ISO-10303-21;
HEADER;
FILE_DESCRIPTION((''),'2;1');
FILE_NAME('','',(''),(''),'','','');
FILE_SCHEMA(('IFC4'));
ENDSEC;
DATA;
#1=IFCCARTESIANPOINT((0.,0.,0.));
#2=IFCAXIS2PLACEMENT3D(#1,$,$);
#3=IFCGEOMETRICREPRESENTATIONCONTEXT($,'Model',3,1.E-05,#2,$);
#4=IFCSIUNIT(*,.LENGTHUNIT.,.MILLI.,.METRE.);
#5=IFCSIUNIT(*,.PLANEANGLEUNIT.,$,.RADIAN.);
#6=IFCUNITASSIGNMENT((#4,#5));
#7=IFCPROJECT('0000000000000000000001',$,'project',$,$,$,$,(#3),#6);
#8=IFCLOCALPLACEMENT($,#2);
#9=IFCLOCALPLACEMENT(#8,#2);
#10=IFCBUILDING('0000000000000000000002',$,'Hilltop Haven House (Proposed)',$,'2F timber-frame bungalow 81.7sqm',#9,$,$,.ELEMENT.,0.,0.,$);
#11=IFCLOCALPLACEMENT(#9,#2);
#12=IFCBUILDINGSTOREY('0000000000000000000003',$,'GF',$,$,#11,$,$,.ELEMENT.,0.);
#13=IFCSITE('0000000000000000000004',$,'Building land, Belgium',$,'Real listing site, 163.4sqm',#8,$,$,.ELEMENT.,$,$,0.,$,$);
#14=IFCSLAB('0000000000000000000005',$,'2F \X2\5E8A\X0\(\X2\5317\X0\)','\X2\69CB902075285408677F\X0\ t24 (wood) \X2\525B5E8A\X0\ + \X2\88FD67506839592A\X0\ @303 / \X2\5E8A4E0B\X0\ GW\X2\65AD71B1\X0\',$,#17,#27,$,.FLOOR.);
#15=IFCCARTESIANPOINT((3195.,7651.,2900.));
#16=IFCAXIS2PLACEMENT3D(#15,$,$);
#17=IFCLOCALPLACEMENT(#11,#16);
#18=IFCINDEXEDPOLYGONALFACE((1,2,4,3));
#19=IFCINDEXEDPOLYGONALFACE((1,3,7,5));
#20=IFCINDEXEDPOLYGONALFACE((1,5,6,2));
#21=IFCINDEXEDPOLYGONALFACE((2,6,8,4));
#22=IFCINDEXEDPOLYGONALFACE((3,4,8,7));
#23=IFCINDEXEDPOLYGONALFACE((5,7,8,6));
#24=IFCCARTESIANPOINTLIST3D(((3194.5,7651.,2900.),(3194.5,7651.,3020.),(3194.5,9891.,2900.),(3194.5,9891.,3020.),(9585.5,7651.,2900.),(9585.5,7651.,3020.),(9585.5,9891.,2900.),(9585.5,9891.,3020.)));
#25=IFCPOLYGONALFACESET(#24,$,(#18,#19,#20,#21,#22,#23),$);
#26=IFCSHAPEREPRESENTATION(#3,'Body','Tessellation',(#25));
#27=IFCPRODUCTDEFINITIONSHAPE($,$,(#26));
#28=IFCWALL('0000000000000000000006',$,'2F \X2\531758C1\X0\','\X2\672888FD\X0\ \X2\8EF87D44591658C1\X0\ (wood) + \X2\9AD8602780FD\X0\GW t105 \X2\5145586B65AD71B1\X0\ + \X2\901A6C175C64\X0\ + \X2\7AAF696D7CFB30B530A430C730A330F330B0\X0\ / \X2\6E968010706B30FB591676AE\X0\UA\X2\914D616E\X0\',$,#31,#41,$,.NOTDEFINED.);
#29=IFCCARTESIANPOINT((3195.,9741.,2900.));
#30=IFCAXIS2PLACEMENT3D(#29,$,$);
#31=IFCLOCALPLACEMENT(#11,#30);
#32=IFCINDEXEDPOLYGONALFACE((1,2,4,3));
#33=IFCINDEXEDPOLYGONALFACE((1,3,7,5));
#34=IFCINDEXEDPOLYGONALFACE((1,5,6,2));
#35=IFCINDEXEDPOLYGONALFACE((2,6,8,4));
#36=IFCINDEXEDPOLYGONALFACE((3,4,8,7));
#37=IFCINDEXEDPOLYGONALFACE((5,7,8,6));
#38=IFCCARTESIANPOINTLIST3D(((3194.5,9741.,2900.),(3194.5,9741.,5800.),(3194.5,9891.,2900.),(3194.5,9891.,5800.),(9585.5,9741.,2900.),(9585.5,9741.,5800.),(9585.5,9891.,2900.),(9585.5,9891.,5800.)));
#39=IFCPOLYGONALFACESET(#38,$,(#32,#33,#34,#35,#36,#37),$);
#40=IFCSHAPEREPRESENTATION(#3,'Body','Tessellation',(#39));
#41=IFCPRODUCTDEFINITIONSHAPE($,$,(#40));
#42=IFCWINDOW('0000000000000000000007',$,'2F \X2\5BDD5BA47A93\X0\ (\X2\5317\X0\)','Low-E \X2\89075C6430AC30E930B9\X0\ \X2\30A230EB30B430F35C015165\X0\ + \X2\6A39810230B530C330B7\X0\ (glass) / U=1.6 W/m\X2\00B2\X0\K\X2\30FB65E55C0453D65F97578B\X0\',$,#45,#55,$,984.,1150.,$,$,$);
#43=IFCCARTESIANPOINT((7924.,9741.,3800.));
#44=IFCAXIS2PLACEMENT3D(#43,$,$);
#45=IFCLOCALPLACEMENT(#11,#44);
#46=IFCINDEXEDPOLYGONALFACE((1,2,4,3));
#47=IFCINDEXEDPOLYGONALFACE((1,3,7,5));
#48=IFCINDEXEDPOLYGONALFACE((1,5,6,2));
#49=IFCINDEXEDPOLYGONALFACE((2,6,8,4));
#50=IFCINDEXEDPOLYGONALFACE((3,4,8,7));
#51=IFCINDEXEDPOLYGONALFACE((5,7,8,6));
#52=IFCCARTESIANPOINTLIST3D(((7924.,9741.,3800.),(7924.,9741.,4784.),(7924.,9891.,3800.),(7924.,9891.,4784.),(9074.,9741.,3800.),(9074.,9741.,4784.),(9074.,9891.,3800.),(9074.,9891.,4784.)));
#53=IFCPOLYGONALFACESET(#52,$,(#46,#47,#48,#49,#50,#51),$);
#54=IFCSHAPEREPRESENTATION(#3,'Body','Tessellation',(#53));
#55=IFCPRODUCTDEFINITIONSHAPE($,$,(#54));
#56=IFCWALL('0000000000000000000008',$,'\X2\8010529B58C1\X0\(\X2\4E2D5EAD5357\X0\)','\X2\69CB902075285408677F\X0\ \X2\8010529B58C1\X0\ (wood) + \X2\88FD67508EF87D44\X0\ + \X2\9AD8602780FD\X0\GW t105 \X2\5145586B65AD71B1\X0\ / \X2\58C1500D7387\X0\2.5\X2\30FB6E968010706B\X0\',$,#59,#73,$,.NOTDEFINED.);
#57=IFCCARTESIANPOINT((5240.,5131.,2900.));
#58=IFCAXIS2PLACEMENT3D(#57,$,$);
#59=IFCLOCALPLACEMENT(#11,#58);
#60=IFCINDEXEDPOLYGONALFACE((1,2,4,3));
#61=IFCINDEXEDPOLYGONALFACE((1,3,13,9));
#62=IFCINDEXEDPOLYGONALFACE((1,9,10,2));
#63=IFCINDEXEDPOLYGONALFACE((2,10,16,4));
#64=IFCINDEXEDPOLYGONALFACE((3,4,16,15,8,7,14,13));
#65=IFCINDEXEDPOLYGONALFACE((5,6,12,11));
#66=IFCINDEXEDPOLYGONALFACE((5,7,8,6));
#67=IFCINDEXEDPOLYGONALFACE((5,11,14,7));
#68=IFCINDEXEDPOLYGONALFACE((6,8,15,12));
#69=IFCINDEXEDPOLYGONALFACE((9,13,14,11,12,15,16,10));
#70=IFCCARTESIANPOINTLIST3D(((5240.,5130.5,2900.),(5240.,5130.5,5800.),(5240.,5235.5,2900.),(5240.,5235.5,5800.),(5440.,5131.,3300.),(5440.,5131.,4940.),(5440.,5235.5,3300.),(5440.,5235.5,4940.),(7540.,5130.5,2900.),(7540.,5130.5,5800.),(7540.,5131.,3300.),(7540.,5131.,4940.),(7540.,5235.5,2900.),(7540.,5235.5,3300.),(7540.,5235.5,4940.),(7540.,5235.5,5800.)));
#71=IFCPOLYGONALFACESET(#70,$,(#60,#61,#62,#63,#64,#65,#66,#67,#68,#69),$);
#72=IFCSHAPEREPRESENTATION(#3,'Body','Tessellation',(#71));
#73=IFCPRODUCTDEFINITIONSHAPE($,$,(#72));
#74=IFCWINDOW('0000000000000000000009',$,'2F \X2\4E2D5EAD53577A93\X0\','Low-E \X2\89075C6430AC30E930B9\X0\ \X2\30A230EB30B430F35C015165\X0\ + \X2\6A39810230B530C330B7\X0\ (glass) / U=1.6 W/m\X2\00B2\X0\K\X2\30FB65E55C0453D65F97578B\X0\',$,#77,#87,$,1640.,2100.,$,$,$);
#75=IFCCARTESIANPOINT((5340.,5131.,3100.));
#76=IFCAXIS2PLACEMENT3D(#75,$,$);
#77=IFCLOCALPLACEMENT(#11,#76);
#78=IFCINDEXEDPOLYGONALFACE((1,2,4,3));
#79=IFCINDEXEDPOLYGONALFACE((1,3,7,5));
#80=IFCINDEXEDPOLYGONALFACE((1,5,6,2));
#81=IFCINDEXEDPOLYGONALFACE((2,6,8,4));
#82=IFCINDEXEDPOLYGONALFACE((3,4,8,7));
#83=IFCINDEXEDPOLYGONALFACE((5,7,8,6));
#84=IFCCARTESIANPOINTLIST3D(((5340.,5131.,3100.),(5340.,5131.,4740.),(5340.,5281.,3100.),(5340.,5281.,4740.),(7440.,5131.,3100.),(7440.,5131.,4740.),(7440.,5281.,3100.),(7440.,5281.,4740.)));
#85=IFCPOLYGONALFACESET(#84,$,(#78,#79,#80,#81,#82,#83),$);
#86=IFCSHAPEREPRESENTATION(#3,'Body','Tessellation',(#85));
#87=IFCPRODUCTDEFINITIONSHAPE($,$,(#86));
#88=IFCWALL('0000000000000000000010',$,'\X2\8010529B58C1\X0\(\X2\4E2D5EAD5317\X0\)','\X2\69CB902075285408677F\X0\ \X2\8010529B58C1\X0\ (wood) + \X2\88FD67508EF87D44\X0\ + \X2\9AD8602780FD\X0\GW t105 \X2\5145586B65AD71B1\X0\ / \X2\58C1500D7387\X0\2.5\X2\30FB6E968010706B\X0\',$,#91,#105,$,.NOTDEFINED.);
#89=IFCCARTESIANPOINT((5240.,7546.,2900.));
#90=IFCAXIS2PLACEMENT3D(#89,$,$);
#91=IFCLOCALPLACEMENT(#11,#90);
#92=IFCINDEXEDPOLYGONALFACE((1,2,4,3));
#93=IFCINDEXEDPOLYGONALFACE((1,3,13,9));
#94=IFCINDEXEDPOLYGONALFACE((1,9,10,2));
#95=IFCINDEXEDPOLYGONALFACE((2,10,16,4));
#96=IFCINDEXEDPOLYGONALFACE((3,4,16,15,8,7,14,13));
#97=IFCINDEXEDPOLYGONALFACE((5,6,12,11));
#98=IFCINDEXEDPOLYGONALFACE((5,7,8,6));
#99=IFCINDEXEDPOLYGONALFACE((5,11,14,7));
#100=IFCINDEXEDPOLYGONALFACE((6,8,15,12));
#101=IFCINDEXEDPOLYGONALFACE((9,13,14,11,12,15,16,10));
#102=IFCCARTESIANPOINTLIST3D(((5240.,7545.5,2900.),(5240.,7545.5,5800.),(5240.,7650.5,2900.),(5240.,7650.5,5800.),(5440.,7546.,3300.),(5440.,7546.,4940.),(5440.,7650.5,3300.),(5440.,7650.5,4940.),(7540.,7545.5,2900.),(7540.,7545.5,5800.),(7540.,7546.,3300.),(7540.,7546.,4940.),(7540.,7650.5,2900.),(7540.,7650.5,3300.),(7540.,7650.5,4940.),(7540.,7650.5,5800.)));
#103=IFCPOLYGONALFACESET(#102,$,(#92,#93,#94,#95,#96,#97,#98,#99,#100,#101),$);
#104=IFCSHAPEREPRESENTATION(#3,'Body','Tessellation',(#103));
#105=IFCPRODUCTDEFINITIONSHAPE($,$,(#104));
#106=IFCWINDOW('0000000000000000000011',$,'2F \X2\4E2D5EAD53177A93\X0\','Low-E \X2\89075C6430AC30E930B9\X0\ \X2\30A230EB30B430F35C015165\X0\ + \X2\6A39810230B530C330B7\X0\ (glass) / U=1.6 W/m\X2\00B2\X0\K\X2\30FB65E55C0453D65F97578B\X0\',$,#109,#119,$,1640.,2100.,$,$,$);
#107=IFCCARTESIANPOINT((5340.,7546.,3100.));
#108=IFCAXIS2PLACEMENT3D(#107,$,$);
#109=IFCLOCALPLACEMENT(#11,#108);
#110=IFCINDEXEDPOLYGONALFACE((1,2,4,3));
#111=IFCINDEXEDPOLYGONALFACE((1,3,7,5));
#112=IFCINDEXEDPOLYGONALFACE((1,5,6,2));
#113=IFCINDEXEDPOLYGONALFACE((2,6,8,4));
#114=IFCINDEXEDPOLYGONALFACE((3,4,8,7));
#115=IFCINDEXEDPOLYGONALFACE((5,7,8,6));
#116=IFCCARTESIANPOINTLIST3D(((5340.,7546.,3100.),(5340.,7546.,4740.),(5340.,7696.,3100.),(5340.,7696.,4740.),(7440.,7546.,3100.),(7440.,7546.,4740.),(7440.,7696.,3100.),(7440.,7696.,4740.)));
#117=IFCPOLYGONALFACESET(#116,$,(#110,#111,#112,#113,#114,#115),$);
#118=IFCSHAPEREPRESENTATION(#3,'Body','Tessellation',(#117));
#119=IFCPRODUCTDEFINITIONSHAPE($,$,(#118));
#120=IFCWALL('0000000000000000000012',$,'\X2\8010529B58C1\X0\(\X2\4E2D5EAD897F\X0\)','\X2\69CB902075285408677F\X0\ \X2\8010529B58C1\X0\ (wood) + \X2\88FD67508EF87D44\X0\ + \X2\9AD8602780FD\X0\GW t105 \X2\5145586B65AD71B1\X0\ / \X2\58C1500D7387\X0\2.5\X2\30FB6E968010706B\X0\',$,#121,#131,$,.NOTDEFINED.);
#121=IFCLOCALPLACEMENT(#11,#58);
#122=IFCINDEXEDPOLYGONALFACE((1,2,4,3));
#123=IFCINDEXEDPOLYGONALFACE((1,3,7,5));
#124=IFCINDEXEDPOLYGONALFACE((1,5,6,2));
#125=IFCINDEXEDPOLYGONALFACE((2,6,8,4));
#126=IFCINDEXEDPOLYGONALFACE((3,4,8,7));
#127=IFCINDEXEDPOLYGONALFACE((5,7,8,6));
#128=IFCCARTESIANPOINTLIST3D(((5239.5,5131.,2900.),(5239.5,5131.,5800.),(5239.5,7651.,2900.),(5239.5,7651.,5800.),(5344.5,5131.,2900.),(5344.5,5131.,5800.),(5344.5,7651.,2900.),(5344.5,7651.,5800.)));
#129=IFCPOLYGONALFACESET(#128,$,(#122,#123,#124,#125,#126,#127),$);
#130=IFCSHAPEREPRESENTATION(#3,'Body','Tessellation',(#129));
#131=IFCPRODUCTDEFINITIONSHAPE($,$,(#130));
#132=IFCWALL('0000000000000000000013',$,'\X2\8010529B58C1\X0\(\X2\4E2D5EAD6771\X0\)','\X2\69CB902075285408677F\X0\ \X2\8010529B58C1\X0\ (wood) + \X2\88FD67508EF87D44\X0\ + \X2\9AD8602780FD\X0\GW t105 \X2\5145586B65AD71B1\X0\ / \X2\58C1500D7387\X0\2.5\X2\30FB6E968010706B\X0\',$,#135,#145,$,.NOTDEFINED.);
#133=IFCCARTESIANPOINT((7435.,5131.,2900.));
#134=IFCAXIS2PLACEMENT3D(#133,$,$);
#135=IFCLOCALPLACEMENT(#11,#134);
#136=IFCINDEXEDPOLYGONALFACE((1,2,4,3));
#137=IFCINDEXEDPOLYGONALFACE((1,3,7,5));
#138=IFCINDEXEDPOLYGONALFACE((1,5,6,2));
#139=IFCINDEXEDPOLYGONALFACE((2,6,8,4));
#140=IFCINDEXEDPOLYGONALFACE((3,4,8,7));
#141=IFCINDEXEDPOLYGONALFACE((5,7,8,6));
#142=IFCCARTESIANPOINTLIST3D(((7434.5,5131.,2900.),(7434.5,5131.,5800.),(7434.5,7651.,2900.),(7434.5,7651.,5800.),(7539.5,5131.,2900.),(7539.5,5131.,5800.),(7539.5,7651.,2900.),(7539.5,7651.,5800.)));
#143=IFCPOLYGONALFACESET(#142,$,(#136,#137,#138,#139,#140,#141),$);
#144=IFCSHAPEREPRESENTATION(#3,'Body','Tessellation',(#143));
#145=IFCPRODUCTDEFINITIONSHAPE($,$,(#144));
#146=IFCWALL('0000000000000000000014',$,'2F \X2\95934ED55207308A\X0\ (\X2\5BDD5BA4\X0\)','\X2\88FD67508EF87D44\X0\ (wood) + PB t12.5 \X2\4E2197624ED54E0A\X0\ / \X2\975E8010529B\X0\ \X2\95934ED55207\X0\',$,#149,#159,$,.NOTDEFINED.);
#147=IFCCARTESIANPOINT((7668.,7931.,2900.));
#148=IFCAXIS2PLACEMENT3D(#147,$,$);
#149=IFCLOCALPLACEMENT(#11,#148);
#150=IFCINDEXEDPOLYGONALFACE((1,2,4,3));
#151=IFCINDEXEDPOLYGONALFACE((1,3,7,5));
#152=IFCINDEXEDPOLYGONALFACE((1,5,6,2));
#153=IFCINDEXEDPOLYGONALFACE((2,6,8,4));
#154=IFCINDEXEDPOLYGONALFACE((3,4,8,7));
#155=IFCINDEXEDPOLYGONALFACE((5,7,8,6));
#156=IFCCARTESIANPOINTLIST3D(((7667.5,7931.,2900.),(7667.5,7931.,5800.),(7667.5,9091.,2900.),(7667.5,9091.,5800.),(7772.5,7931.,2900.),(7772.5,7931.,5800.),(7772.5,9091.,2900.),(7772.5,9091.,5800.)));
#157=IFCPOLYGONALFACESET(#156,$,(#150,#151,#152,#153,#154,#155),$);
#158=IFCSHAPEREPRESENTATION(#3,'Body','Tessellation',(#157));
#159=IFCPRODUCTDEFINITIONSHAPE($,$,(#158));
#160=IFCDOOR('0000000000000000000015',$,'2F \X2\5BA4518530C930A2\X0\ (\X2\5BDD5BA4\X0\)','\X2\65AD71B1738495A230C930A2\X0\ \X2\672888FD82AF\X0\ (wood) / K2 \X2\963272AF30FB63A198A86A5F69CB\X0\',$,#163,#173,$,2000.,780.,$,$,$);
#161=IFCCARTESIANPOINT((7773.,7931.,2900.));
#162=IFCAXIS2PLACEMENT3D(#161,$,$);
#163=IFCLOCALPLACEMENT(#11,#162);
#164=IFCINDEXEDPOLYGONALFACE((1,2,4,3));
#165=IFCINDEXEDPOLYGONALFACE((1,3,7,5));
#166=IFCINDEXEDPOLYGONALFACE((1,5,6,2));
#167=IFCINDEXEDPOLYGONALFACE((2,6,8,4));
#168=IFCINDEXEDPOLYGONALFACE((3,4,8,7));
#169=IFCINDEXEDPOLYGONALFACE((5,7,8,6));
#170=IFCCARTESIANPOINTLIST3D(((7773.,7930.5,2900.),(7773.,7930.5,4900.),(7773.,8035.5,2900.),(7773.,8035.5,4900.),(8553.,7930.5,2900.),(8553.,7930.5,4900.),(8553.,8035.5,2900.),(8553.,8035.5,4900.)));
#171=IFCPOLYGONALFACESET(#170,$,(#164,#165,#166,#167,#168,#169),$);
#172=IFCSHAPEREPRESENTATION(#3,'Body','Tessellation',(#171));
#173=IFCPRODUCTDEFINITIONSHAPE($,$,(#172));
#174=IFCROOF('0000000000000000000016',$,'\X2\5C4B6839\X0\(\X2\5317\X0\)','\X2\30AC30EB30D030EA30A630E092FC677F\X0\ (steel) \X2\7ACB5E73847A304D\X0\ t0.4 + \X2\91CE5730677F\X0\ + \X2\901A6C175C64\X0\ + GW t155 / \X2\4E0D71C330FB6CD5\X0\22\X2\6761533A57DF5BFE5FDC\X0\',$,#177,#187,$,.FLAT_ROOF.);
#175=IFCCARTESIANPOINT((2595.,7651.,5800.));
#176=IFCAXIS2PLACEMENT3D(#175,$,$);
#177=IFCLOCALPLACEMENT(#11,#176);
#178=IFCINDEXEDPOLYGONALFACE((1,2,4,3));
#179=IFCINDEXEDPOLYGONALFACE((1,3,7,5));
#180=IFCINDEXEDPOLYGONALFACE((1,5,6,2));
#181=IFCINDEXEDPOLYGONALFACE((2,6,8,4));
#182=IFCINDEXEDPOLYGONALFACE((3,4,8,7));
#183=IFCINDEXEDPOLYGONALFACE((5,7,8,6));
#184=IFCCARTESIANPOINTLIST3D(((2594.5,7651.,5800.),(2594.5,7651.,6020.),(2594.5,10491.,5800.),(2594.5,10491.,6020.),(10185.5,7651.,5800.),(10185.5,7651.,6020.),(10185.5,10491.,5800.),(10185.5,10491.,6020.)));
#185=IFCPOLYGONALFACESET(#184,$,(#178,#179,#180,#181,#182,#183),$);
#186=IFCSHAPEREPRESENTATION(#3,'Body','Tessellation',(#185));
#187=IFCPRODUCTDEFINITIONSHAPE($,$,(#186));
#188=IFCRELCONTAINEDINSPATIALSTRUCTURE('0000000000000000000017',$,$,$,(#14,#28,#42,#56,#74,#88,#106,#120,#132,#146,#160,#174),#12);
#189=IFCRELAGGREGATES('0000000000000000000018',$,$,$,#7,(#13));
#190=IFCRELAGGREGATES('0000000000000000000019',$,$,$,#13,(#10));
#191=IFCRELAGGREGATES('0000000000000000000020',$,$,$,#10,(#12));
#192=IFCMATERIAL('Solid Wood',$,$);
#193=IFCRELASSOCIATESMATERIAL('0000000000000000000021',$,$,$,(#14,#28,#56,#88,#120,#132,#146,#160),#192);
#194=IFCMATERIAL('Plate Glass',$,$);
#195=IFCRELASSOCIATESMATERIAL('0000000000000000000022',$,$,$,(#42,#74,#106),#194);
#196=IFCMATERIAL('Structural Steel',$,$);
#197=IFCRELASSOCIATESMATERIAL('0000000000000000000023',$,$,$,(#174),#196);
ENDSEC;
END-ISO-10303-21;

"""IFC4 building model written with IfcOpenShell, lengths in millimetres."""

from ifc_helpers import new_model, si_unit, frame, frame_2d, origin, place, context, project, spatial, rectangle, extrude, material, element, fill, save


model = new_model("IFC4")

# Units and contexts
model_context = context("Model", 3, precision=1e-05, world=origin())
ifc_project = project(units=[si_unit("LENGTHUNIT", "METRE", prefix="MILLI"), si_unit("PLANEANGLEUNIT", "RADIAN")], contexts=[model_context])

# Site, building, storey
site_placement = place(None, origin())
site = spatial("IfcSite", under=ifc_project, at=site_placement, Name="Building land, Belgium", ObjectType="Real listing site, 163.4sqm", CompositionType="ELEMENT", RefElevation=0.0)
building_placement = place(site_placement, origin())
building = spatial("IfcBuilding", under=site, at=building_placement, Name="Hilltop Haven House (Proposed)", ObjectType="2F timber-frame bungalow 81.7sqm", CompositionType="ELEMENT", ElevationOfRefHeight=0.0, ElevationOfTerrain=0.0)
storey_placement = place(building_placement, origin())
storey = spatial("IfcBuildingStorey", under=building, at=storey_placement, Name="GF", CompositionType="ELEMENT", Elevation=0.0)

# Slab
ifc_material_1 = material(Name="Solid Wood")
slab_placement = place(storey_placement, frame((3195.0, 7651.0, 2900.0)))
element("IfcSlab", 1, at=slab_placement, inside=storey, material=ifc_material_1, Name="2F 床(北)", Description="構造用合板 t24 (wood) 剛床 + 製材根太 @303 / 床下 GW断熱", PredefinedType="FLOOR", context=model_context, shape_type="SweptSolid", body=[
    extrude(rectangle(XDim=6391.0, YDim=2240.0, at=frame_2d((3195.0, 1120.0))), frame((3195.0, 7651.0, 2900.0)), (0.0, 0.0, 1.0), 120.0),
])

# Walls, openings, windows
wall_1_placement = place(storey_placement, frame((3195.0, 9741.0, 2900.0)))
wall_1 = element("IfcWall", 2, at=wall_1_placement, inside=storey, material=ifc_material_1, Name="2F 北壁", Description="木製 軸組外壁 (wood) + 高性能GW t105 充填断熱 + 通気層 + 窯業系サイディング / 準耐火・外皮UA配慮", PredefinedType="NOTDEFINED", context=model_context, shape_type="SweptSolid", body=[
    extrude(rectangle(XDim=6391.0, YDim=150.0, at=frame_2d((3195.0, 75.0))), frame((3195.0, 9741.0, 2900.0)), (0.0, 0.0, 1.0), 2900.0),
])
opening_1_placement = place(storey_placement, frame((7924.0, 9741.0, 3800.0)))
opening_1 = element("IfcOpeningElement", 3, at=opening_1_placement, cuts=wall_1, PredefinedType="NOTDEFINED", context=model_context, shape_type="SweptSolid", body=[
    extrude(rectangle(XDim=1150.0, YDim=150.0, at=frame_2d((575.0, 75.0))), frame((7924.0, 9741.0, 3800.0)), (0.0, 0.0, 1.0), 984.0),
])
ifc_material_2 = material(Name="Plate Glass")
window_1_placement = place(storey_placement, frame((7924.0, 9741.0, 3800.0)))
window_1 = element("IfcWindow", 4, at=window_1_placement, inside=storey, material=ifc_material_2, Name="2F 寝室窓 (北)", Description="Low-E 複層ガラス アルゴン封入 + 樹脂サッシ (glass) / U=1.6 W/m²K・日射取得型", OverallHeight=984.0, OverallWidth=1150.0, context=model_context, shape_type="SweptSolid", body=[
    extrude(rectangle(XDim=1150.0, YDim=150.0, at=frame_2d((575.0, 75.0))), frame((7924.0, 9741.0, 3800.0)), (0.0, 0.0, 1.0), 984.0),
])
fill(opening_1, window_1)
wall_2_placement = place(storey_placement, frame((5240.0, 5131.0, 2900.0)))
wall_2 = element("IfcWall", 5, at=wall_2_placement, inside=storey, material=ifc_material_1, Name="耐力壁(中庭南)", Description="構造用合板 耐力壁 (wood) + 製材軸組 + 高性能GW t105 充填断熱 / 壁倍率2.5・準耐火", PredefinedType="NOTDEFINED", context=model_context, shape_type="SweptSolid", body=[
    extrude(rectangle(XDim=2300.0, YDim=105.0, at=frame_2d((1150.0, 52.0))), frame((5240.0, 5131.0, 2900.0)), (0.0, 0.0, 1.0), 2900.0),
])
opening_2_placement = place(storey_placement, frame((5340.0, 5131.0, 3100.0)))
opening_2 = element("IfcOpeningElement", 6, at=opening_2_placement, cuts=wall_2, PredefinedType="NOTDEFINED", context=model_context, shape_type="SweptSolid", body=[
    extrude(rectangle(XDim=2100.0, YDim=150.0, at=frame_2d((1050.0, 75.0))), frame((5340.0, 5131.0, 3100.0)), (0.0, 0.0, 1.0), 1640.0),
])
window_2_placement = place(storey_placement, frame((5340.0, 5131.0, 3100.0)))
window_2 = element("IfcWindow", 7, at=window_2_placement, inside=storey, material=ifc_material_2, Name="2F 中庭南窓", Description="Low-E 複層ガラス アルゴン封入 + 樹脂サッシ (glass) / U=1.6 W/m²K・日射取得型", OverallHeight=1640.0, OverallWidth=2100.0, context=model_context, shape_type="SweptSolid", body=[
    extrude(rectangle(XDim=2100.0, YDim=150.0, at=frame_2d((1050.0, 75.0))), frame((5340.0, 5131.0, 3100.0)), (0.0, 0.0, 1.0), 1640.0),
])
fill(opening_2, window_2)
wall_3_placement = place(storey_placement, frame((5240.0, 7546.0, 2900.0)))
wall_3 = element("IfcWall", 8, at=wall_3_placement, inside=storey, material=ifc_material_1, Name="耐力壁(中庭北)", Description="構造用合板 耐力壁 (wood) + 製材軸組 + 高性能GW t105 充填断熱 / 壁倍率2.5・準耐火", PredefinedType="NOTDEFINED", context=model_context, shape_type="SweptSolid", body=[
    extrude(rectangle(XDim=2300.0, YDim=105.0, at=frame_2d((1150.0, 52.0))), frame((5240.0, 7546.0, 2900.0)), (0.0, 0.0, 1.0), 2900.0),
])
opening_3_placement = place(storey_placement, frame((5340.0, 7546.0, 3100.0)))
opening_3 = element("IfcOpeningElement", 9, at=opening_3_placement, cuts=wall_3, PredefinedType="NOTDEFINED", context=model_context, shape_type="SweptSolid", body=[
    extrude(rectangle(XDim=2100.0, YDim=150.0, at=frame_2d((1050.0, 75.0))), frame((5340.0, 7546.0, 3100.0)), (0.0, 0.0, 1.0), 1640.0),
])
window_3_placement = place(storey_placement, frame((5340.0, 7546.0, 3100.0)))
window_3 = element("IfcWindow", 10, at=window_3_placement, inside=storey, material=ifc_material_2, Name="2F 中庭北窓", Description="Low-E 複層ガラス アルゴン封入 + 樹脂サッシ (glass) / U=1.6 W/m²K・日射取得型", OverallHeight=1640.0, OverallWidth=2100.0, context=model_context, shape_type="SweptSolid", body=[
    extrude(rectangle(XDim=2100.0, YDim=150.0, at=frame_2d((1050.0, 75.0))), frame((5340.0, 7546.0, 3100.0)), (0.0, 0.0, 1.0), 1640.0),
])
fill(opening_3, window_3)

# Walls
wall_4_placement = place(storey_placement, frame((5240.0, 5131.0, 2900.0)))
element("IfcWall", 11, at=wall_4_placement, inside=storey, material=ifc_material_1, Name="耐力壁(中庭西)", Description="構造用合板 耐力壁 (wood) + 製材軸組 + 高性能GW t105 充填断熱 / 壁倍率2.5・準耐火", PredefinedType="NOTDEFINED", context=model_context, shape_type="SweptSolid", body=[
    extrude(rectangle(XDim=105.0, YDim=2520.0, at=frame_2d((52.0, 1260.0))), frame((5240.0, 5131.0, 2900.0)), (0.0, 0.0, 1.0), 2900.0),
])
wall_5_placement = place(storey_placement, frame((7435.0, 5131.0, 2900.0)))
element("IfcWall", 12, at=wall_5_placement, inside=storey, material=ifc_material_1, Name="耐力壁(中庭東)", Description="構造用合板 耐力壁 (wood) + 製材軸組 + 高性能GW t105 充填断熱 / 壁倍率2.5・準耐火", PredefinedType="NOTDEFINED", context=model_context, shape_type="SweptSolid", body=[
    extrude(rectangle(XDim=105.0, YDim=2520.0, at=frame_2d((52.0, 1260.0))), frame((7435.0, 5131.0, 2900.0)), (0.0, 0.0, 1.0), 2900.0),
])
wall_6_placement = place(storey_placement, frame((7668.0, 7931.0, 2900.0)))
element("IfcWall", 13, at=wall_6_placement, inside=storey, material=ifc_material_1, Name="2F 間仕切り (寝室)", Description="製材軸組 (wood) + PB t12.5 両面仕上 / 非耐力 間仕切", PredefinedType="NOTDEFINED", context=model_context, shape_type="SweptSolid", body=[
    extrude(rectangle(XDim=105.0, YDim=1160.0, at=frame_2d((52.0, 580.0))), frame((7668.0, 7931.0, 2900.0)), (0.0, 0.0, 1.0), 2900.0),
])

# Door
door_placement = place(storey_placement, frame((7773.0, 7931.0, 2900.0)))
element("IfcDoor", 14, at=door_placement, inside=storey, material=ifc_material_1, Name="2F 室内ドア (寝室)", Description="断熱玄関ドア 木製芯 (wood) / K2 防犯・採風機構", OverallHeight=2000.0, OverallWidth=780.0, context=model_context, shape_type="SweptSolid", body=[
    extrude(rectangle(XDim=780.0, YDim=105.0, at=frame_2d((390.0, 52.0))), frame((7773.0, 7931.0, 2900.0)), (0.0, 0.0, 1.0), 2000.0),
])

# Roof
ifc_material_3 = material(Name="Structural Steel")
for number, where, name in (
    (15, (2595.0, 7651.0, 5800.0), "屋根(北)"),
):
    element("IfcRoof", number, at=place(storey_placement, frame(where)), inside=storey, material=ifc_material_3, Name=name, Description="ガルバリウム鋼板 (steel) 立平葺き t0.4 + 野地板 + 通気層 + GW t155 / 不燃・法22条区域対応", PredefinedType="FLAT_ROOF", context=model_context, shape_type="SweptSolid", body=[
        extrude(rectangle(XDim=7591.0, YDim=2840.0, at=frame_2d((3795.0, 1420.0))), frame((2595.0, 7651.0, 5800.0)), (0.0, 0.0, 1.0), 220.0),
    ])

save(model, "model.ifc")
